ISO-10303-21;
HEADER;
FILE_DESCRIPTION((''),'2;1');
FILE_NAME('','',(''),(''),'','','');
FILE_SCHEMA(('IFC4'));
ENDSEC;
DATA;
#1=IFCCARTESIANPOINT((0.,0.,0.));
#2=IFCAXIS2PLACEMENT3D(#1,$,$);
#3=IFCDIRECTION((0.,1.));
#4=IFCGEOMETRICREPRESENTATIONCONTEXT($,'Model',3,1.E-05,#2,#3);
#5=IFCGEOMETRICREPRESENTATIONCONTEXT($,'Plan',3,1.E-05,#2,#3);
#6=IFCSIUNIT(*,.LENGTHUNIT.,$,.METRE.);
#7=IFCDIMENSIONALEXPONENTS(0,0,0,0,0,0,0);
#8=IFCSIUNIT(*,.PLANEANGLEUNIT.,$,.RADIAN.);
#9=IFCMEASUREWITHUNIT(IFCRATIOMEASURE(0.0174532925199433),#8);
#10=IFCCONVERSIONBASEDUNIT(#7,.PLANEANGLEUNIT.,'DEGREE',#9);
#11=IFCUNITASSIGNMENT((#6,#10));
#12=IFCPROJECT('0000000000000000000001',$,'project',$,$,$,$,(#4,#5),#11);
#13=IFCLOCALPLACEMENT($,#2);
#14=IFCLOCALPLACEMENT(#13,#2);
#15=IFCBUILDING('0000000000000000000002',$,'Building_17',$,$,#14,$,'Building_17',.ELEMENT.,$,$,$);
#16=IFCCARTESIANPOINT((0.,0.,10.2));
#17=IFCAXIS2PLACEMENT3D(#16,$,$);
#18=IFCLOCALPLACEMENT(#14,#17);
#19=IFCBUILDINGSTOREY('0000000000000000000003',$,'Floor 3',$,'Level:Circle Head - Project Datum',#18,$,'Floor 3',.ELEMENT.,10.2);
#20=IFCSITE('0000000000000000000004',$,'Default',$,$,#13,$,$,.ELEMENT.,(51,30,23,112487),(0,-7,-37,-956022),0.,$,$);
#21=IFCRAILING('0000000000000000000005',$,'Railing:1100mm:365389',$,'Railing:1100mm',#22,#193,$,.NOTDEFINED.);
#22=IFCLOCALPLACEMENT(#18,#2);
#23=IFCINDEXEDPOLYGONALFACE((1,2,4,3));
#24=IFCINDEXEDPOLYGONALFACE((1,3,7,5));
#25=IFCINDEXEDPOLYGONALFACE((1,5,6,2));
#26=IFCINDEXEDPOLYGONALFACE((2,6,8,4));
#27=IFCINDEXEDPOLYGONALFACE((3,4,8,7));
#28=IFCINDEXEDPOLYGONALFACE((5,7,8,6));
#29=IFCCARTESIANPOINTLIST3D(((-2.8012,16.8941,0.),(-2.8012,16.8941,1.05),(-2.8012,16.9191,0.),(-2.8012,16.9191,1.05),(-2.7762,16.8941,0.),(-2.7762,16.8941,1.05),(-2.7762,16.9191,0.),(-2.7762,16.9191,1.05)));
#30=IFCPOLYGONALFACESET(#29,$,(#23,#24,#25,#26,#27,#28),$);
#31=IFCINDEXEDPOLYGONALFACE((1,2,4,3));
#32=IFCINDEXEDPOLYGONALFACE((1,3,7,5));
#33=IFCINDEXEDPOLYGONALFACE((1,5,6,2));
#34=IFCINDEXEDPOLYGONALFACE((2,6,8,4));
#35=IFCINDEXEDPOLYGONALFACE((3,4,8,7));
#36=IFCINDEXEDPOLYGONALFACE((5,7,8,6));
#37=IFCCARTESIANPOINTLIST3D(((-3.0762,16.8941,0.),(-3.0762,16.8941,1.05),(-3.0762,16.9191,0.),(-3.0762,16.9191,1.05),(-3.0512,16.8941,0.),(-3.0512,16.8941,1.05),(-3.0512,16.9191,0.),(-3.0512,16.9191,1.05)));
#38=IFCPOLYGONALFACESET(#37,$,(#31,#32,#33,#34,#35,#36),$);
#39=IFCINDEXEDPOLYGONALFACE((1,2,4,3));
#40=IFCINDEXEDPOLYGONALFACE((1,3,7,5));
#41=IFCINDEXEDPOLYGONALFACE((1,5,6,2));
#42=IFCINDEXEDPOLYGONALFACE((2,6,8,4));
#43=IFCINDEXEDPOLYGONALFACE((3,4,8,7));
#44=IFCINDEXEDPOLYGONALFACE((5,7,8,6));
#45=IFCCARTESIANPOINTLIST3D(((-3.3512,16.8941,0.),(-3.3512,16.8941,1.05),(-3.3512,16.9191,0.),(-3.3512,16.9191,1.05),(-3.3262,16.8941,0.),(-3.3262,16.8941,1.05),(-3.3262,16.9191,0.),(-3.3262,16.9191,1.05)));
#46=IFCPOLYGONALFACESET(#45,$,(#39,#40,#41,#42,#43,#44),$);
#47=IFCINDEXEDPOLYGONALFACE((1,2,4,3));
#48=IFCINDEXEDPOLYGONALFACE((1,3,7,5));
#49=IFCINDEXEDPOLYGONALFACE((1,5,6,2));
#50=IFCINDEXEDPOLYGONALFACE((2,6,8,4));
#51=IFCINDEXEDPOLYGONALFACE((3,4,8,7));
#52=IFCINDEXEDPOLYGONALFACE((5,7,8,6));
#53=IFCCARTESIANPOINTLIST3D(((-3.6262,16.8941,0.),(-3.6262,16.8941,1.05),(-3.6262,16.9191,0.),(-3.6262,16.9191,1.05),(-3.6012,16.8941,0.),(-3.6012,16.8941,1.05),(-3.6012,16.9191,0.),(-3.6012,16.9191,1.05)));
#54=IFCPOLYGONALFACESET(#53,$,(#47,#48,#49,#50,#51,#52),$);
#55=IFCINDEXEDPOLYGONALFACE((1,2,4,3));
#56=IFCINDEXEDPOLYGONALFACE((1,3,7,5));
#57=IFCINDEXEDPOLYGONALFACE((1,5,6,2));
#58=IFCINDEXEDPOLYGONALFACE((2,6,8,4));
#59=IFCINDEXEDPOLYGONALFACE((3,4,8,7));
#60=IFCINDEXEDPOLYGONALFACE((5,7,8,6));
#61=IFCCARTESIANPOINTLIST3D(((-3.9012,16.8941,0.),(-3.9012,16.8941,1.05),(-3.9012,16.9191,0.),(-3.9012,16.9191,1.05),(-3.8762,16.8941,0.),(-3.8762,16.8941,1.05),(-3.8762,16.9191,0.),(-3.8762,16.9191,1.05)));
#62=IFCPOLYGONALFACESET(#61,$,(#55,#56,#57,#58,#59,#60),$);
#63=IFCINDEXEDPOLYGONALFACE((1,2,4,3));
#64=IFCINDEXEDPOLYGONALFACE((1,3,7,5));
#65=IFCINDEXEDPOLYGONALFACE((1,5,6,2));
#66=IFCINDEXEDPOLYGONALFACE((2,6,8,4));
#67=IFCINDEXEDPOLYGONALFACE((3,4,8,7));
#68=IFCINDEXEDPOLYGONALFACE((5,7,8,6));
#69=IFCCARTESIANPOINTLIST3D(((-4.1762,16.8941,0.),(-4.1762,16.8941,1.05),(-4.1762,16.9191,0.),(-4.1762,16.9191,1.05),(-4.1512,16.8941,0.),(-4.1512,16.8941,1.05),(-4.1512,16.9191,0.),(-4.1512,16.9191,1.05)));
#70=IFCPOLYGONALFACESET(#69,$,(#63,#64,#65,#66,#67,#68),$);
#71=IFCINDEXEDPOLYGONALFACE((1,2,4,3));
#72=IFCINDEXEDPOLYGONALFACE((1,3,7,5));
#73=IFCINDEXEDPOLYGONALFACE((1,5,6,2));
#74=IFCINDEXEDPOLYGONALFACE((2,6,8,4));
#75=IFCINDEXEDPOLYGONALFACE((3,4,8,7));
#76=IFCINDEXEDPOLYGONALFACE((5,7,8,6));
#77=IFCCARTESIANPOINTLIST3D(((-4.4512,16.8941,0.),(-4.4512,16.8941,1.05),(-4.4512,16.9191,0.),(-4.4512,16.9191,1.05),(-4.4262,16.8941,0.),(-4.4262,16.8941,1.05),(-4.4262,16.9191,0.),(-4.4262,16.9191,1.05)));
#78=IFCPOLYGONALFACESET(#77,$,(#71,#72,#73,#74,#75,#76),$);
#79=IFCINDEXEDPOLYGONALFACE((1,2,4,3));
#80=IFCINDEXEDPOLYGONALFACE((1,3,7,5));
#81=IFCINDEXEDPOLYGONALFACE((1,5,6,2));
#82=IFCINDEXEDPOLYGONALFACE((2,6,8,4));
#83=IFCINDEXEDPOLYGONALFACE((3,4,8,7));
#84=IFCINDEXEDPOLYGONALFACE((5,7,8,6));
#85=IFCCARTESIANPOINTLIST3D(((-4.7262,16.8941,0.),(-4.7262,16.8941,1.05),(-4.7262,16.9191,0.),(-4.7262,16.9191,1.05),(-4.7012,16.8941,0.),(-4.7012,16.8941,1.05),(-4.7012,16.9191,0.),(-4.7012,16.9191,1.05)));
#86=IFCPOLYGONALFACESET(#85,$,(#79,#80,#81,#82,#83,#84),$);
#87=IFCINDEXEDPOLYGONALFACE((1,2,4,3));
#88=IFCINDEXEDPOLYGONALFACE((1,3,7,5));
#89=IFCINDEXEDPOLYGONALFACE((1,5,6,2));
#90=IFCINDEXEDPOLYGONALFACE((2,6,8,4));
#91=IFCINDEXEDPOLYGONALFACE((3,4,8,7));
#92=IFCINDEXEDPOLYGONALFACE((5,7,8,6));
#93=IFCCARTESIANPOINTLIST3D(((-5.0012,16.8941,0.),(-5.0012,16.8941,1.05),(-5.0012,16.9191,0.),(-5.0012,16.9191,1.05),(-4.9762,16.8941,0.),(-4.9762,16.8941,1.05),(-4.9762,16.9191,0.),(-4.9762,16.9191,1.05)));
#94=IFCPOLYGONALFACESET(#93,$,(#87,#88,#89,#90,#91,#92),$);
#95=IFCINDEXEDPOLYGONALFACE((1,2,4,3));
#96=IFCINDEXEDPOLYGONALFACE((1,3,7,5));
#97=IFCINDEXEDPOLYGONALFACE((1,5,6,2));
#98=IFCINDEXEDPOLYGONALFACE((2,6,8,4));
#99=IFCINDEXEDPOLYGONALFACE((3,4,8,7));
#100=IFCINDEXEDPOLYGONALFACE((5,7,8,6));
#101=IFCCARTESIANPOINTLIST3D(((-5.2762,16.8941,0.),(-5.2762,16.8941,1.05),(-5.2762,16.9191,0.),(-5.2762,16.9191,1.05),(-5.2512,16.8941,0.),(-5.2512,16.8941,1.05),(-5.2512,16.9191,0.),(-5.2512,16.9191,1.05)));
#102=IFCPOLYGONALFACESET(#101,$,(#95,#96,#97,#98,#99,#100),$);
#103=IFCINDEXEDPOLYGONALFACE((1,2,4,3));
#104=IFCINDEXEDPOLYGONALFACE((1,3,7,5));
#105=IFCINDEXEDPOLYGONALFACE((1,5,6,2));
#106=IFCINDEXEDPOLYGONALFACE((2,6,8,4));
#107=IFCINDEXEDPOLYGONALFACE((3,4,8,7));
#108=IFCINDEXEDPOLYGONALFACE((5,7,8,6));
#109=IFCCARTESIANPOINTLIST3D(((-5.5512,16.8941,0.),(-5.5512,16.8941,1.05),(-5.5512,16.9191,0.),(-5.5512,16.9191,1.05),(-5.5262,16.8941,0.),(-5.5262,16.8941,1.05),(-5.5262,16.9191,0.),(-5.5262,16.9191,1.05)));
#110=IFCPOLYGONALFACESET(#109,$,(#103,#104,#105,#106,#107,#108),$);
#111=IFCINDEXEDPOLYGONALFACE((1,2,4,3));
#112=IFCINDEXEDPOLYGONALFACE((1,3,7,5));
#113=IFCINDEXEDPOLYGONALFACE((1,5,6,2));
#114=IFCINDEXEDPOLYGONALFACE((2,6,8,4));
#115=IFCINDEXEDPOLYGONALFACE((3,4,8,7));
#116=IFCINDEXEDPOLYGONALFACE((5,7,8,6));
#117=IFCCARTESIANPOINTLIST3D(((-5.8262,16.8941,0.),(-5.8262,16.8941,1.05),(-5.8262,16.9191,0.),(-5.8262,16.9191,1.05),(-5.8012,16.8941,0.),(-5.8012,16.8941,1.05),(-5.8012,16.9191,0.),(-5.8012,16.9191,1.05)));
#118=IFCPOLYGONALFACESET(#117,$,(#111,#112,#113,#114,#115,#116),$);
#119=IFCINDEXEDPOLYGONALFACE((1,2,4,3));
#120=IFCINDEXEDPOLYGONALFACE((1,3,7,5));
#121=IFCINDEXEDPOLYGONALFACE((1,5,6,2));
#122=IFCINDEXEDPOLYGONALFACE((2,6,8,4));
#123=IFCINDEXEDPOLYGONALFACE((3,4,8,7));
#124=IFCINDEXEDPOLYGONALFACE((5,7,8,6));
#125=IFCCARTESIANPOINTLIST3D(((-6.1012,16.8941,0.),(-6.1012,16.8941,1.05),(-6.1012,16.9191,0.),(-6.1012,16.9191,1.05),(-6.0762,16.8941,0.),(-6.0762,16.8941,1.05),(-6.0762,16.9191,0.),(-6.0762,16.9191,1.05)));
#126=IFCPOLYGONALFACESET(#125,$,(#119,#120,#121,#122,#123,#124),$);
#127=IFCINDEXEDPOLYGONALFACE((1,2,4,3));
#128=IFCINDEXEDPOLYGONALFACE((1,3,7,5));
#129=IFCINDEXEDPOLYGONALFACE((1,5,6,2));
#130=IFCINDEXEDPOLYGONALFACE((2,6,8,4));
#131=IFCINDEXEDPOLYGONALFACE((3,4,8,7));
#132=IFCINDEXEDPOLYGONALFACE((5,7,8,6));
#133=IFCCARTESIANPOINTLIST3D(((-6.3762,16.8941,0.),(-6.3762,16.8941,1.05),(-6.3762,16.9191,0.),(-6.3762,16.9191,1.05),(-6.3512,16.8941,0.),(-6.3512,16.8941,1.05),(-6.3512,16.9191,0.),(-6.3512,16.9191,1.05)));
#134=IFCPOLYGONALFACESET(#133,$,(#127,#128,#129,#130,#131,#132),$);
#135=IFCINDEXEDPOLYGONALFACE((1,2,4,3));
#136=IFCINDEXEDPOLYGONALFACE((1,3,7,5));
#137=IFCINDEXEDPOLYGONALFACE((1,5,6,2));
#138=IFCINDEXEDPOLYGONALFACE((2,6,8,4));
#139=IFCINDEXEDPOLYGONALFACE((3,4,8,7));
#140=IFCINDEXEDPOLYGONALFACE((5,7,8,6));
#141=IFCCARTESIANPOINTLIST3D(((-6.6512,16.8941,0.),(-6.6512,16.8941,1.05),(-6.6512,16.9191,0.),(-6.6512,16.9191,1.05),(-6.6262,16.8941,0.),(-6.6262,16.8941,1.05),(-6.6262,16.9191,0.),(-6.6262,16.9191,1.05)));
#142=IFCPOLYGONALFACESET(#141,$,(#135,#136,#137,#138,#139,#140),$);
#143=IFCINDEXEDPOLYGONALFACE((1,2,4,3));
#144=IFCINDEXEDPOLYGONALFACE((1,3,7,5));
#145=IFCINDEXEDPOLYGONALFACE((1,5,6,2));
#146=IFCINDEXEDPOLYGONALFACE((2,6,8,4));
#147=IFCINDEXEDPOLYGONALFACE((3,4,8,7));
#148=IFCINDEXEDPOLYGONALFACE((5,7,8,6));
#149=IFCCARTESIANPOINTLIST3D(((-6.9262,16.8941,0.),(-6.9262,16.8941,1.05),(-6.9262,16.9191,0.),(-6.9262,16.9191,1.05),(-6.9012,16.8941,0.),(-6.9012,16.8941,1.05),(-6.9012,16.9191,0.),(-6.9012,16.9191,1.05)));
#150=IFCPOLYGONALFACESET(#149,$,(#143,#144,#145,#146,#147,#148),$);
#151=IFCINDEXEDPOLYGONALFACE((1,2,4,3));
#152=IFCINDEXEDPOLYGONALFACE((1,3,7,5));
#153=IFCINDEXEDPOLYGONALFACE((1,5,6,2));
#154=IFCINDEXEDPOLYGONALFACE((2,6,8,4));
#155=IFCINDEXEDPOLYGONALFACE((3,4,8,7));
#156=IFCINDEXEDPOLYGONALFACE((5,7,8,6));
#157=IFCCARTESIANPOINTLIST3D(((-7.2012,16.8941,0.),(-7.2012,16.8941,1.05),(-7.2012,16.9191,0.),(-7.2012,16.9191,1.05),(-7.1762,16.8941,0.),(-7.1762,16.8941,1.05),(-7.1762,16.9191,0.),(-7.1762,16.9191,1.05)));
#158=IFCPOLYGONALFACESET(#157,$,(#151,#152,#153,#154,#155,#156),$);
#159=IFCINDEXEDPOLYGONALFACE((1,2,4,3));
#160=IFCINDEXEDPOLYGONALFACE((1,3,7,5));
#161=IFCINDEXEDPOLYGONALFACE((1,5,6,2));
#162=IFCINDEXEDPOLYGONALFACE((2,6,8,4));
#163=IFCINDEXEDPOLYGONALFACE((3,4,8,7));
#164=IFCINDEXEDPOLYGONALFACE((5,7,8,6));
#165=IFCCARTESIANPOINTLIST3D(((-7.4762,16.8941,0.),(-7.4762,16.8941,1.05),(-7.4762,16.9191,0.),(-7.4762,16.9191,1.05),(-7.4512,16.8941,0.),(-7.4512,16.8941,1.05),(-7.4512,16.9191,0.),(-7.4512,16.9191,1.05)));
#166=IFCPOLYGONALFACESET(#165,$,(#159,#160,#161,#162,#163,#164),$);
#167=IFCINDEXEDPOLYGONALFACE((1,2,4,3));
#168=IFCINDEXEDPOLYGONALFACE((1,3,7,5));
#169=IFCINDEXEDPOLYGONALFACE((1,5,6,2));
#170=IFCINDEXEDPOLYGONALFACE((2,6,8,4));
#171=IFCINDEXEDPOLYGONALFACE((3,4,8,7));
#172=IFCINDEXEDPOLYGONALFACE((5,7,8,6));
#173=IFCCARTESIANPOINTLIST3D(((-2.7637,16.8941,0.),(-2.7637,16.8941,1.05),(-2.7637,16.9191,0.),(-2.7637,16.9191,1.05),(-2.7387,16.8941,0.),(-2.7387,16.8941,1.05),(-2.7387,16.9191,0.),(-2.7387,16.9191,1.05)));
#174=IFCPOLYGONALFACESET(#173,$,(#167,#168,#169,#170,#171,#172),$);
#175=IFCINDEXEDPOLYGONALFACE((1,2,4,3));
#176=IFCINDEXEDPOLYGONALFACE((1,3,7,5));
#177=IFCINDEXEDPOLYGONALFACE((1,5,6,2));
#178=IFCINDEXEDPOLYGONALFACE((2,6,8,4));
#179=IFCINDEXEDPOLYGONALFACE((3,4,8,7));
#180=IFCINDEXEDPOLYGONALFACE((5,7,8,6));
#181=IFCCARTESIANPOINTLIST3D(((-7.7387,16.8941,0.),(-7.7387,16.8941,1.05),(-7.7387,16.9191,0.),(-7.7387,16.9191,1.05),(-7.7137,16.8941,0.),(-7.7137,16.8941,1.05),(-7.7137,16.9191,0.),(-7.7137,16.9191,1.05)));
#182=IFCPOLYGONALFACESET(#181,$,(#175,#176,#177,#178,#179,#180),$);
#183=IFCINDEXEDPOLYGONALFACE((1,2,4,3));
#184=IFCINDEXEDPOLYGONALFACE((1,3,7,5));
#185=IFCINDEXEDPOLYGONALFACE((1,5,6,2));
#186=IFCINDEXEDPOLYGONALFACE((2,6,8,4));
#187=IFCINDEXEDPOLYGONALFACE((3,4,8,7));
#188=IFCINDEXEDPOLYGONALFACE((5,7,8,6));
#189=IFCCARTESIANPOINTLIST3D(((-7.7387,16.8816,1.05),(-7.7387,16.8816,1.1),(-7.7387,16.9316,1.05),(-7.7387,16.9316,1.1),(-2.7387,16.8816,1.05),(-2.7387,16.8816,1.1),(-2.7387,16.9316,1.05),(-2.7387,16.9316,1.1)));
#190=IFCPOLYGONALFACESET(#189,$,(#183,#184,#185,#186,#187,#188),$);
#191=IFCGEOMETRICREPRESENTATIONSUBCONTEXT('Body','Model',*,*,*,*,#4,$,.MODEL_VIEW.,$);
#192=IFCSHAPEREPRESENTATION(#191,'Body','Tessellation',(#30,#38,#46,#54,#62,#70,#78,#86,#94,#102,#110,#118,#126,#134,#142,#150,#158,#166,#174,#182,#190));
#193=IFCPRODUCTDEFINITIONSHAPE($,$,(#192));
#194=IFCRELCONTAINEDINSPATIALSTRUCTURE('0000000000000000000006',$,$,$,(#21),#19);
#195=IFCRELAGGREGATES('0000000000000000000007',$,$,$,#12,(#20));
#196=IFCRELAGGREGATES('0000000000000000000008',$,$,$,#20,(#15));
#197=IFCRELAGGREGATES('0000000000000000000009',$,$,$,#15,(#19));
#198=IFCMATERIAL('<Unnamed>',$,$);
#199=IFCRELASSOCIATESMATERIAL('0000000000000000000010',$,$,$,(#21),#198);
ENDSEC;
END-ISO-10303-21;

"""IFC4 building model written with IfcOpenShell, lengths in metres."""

from ifc_helpers import new_model, entity, si_unit, converted_unit, direction, frame, origin, place, context, subcontext, project, spatial, indexed_curve, outline, extrude, material, element, save


model = new_model("IFC4")

# Units and contexts
model_context = context("Model", 3, precision=1e-05, world=origin(), true_north=direction((0.0, 1.0)))
plan_context = context("Plan", 3, precision=1e-05, world=origin(), true_north=direction((0.0, 1.0)))
body_context = subcontext(model_context, "Body", "Model", "MODEL_VIEW")
ifc_project = project(units=[si_unit("LENGTHUNIT", "METRE"), converted_unit("PLANEANGLEUNIT", "DEGREE", entity("IfcRatioMeasure", 0.0174532925199433), si_unit("PLANEANGLEUNIT", "RADIAN"), dimensions=[0, 0, 0, 0, 0, 0, 0])], contexts=[model_context, plan_context])

# Site, building, storey
site_placement = place(None, origin())
site = spatial("IfcSite", under=ifc_project, at=site_placement, Name="Default", CompositionType="ELEMENT", RefLatitude=(51, 30, 23, 112487), RefLongitude=(0, -7, -37, -956022), RefElevation=0.0)
building_placement = place(site_placement, origin())
building = spatial("IfcBuilding", under=site, at=building_placement, Name="Building_17", LongName="Building_17", CompositionType="ELEMENT")
storey_placement = place(building_placement, frame((0.0, 0.0, 10.2)))
storey = spatial("IfcBuildingStorey", under=building, at=storey_placement, Name="Floor 3", ObjectType="Level:Circle Head - Project Datum", LongName="Floor 3", CompositionType="ELEMENT", Elevation=10.2)

# Railing
ifc_material_1 = material(Name="<Unnamed>")
railing_1_placement = place(storey_placement, origin())
element("IfcRailing", 1, at=railing_1_placement, inside=storey, material=ifc_material_1, Name="Railing:1100mm:365389", ObjectType="Railing:1100mm", PredefinedType="NOTDEFINED", context=body_context, shape_type="SweptSolid", body=[
    extrude(outline(indexed_curve([(-0.0125, -0.0125), (0.0125, -0.0125), (0.0125, 0.0125), (-0.0125, 0.0125), (-0.0125, -0.0125)], self_intersect=False)), frame((-2.7887, 16.9066, 0.0)), (0.0, 0.0, 1.0), 1.05),
    extrude(outline(indexed_curve([(-0.0125, -0.0125), (0.0125, -0.0125), (0.0125, 0.0125), (-0.0125, 0.0125), (-0.0125, -0.0125)], self_intersect=False)), frame((-3.0637, 16.9066, 0.0)), (0.0, 0.0, 1.0), 1.05),
    extrude(outline(indexed_curve([(-0.0125, -0.0125), (0.0125, -0.0125), (0.0125, 0.0125), (-0.0125, 0.0125), (-0.0125, -0.0125)], self_intersect=False)), frame((-3.3387, 16.9066, 0.0)), (0.0, 0.0, 1.0), 1.05),
    extrude(outline(indexed_curve([(-0.0125, -0.0125), (0.0125, -0.0125), (0.0125, 0.0125), (-0.0125, 0.0125), (-0.0125, -0.0125)], self_intersect=False)), frame((-3.6137, 16.9066, 0.0)), (0.0, 0.0, 1.0), 1.05),
    extrude(outline(indexed_curve([(-0.0125, -0.0125), (0.0125, -0.0125), (0.0125, 0.0125), (-0.0125, 0.0125), (-0.0125, -0.0125)], self_intersect=False)), frame((-3.8887, 16.9066, 0.0)), (0.0, 0.0, 1.0), 1.05),
    extrude(outline(indexed_curve([(-0.0125, -0.0125), (0.0125, -0.0125), (0.0125, 0.0125), (-0.0125, 0.0125), (-0.0125, -0.0125)], self_intersect=False)), frame((-4.1637, 16.9066, 0.0)), (0.0, 0.0, 1.0), 1.05),
    extrude(outline(indexed_curve([(-0.0125, -0.0125), (0.0125, -0.0125), (0.0125, 0.0125), (-0.0125, 0.0125), (-0.0125, -0.0125)], self_intersect=False)), frame((-4.4387, 16.9066, 0.0)), (0.0, 0.0, 1.0), 1.05),
    extrude(outline(indexed_curve([(-0.0125, -0.0125), (0.0125, -0.0125), (0.0125, 0.0125), (-0.0125, 0.0125), (-0.0125, -0.0125)], self_intersect=False)), frame((-4.7137, 16.9066, 0.0)), (0.0, 0.0, 1.0), 1.05),
    extrude(outline(indexed_curve([(-0.0125, -0.0125), (0.0125, -0.0125), (0.0125, 0.0125), (-0.0125, 0.0125), (-0.0125, -0.0125)], self_intersect=False)), frame((-4.9887, 16.9066, 0.0)), (0.0, 0.0, 1.0), 1.05),
    extrude(outline(indexed_curve([(-0.0125, -0.0125), (0.0125, -0.0125), (0.0125, 0.0125), (-0.0125, 0.0125), (-0.0125, -0.0125)], self_intersect=False)), frame((-5.2637, 16.9066, 0.0)), (0.0, 0.0, 1.0), 1.05),
    extrude(outline(indexed_curve([(-0.0125, -0.0125), (0.0125, -0.0125), (0.0125, 0.0125), (-0.0125, 0.0125), (-0.0125, -0.0125)], self_intersect=False)), frame((-5.5387, 16.9066, 0.0)), (0.0, 0.0, 1.0), 1.05),
    extrude(outline(indexed_curve([(-0.0125, -0.0125), (0.0125, -0.0125), (0.0125, 0.0125), (-0.0125, 0.0125), (-0.0125, -0.0125)], self_intersect=False)), frame((-5.8137, 16.9066, 0.0)), (0.0, 0.0, 1.0), 1.05),
    extrude(outline(indexed_curve([(-0.0125, -0.0125), (0.0125, -0.0125), (0.0125, 0.0125), (-0.0125, 0.0125), (-0.0125, -0.0125)], self_intersect=False)), frame((-6.0887, 16.9066, 0.0)), (0.0, 0.0, 1.0), 1.05),
    extrude(outline(indexed_curve([(-0.0125, -0.0125), (0.0125, -0.0125), (0.0125, 0.0125), (-0.0125, 0.0125), (-0.0125, -0.0125)], self_intersect=False)), frame((-6.3637, 16.9066, 0.0)), (0.0, 0.0, 1.0), 1.05),
    extrude(outline(indexed_curve([(-0.0125, -0.0125), (0.0125, -0.0125), (0.0125, 0.0125), (-0.0125, 0.0125), (-0.0125, -0.0125)], self_intersect=False)), frame((-6.6387, 16.9066, 0.0)), (0.0, 0.0, 1.0), 1.05),
    extrude(outline(indexed_curve([(-0.0125, -0.0125), (0.0125, -0.0125), (0.0125, 0.0125), (-0.0125, 0.0125), (-0.0125, -0.0125)], self_intersect=False)), frame((-6.9137, 16.9066, 0.0)), (0.0, 0.0, 1.0), 1.05),
    extrude(outline(indexed_curve([(-0.0125, -0.0125), (0.0125, -0.0125), (0.0125, 0.0125), (-0.0125, 0.0125), (-0.0125, -0.0125)], self_intersect=False)), frame((-7.1887, 16.9066, 0.0)), (0.0, 0.0, 1.0), 1.05),
    extrude(outline(indexed_curve([(-0.0125, -0.0125), (0.0125, -0.0125), (0.0125, 0.0125), (-0.0125, 0.0125), (-0.0125, -0.0125)], self_intersect=False)), frame((-7.4637, 16.9066, 0.0)), (0.0, 0.0, 1.0), 1.05),
    extrude(outline(indexed_curve([(-0.0125, -0.0125), (0.0125, -0.0125), (0.0125, 0.0125), (-0.0125, 0.0125), (-0.0125, -0.0125)], self_intersect=False)), frame((-2.7512, 16.9066, 0.0)), (0.0, 0.0, 1.0), 1.05),
    extrude(outline(indexed_curve([(-0.0125, -0.0125), (0.0125, -0.0125), (0.0125, 0.0125), (-0.0125, 0.0125), (-0.0125, -0.0125)], self_intersect=False)), frame((-7.7262, 16.9066, 0.0)), (0.0, 0.0, 1.0), 1.05),
    extrude(outline(indexed_curve([(-2.5, -0.025), (2.5, -0.025), (2.5, 0.025), (-2.5, 0.025), (-2.5, -0.025)], self_intersect=False)), frame((-5.2387, 16.9066, 1.05)), (0.0, 0.0, 1.0), 0.05),
])

save(model, "model.ifc")
